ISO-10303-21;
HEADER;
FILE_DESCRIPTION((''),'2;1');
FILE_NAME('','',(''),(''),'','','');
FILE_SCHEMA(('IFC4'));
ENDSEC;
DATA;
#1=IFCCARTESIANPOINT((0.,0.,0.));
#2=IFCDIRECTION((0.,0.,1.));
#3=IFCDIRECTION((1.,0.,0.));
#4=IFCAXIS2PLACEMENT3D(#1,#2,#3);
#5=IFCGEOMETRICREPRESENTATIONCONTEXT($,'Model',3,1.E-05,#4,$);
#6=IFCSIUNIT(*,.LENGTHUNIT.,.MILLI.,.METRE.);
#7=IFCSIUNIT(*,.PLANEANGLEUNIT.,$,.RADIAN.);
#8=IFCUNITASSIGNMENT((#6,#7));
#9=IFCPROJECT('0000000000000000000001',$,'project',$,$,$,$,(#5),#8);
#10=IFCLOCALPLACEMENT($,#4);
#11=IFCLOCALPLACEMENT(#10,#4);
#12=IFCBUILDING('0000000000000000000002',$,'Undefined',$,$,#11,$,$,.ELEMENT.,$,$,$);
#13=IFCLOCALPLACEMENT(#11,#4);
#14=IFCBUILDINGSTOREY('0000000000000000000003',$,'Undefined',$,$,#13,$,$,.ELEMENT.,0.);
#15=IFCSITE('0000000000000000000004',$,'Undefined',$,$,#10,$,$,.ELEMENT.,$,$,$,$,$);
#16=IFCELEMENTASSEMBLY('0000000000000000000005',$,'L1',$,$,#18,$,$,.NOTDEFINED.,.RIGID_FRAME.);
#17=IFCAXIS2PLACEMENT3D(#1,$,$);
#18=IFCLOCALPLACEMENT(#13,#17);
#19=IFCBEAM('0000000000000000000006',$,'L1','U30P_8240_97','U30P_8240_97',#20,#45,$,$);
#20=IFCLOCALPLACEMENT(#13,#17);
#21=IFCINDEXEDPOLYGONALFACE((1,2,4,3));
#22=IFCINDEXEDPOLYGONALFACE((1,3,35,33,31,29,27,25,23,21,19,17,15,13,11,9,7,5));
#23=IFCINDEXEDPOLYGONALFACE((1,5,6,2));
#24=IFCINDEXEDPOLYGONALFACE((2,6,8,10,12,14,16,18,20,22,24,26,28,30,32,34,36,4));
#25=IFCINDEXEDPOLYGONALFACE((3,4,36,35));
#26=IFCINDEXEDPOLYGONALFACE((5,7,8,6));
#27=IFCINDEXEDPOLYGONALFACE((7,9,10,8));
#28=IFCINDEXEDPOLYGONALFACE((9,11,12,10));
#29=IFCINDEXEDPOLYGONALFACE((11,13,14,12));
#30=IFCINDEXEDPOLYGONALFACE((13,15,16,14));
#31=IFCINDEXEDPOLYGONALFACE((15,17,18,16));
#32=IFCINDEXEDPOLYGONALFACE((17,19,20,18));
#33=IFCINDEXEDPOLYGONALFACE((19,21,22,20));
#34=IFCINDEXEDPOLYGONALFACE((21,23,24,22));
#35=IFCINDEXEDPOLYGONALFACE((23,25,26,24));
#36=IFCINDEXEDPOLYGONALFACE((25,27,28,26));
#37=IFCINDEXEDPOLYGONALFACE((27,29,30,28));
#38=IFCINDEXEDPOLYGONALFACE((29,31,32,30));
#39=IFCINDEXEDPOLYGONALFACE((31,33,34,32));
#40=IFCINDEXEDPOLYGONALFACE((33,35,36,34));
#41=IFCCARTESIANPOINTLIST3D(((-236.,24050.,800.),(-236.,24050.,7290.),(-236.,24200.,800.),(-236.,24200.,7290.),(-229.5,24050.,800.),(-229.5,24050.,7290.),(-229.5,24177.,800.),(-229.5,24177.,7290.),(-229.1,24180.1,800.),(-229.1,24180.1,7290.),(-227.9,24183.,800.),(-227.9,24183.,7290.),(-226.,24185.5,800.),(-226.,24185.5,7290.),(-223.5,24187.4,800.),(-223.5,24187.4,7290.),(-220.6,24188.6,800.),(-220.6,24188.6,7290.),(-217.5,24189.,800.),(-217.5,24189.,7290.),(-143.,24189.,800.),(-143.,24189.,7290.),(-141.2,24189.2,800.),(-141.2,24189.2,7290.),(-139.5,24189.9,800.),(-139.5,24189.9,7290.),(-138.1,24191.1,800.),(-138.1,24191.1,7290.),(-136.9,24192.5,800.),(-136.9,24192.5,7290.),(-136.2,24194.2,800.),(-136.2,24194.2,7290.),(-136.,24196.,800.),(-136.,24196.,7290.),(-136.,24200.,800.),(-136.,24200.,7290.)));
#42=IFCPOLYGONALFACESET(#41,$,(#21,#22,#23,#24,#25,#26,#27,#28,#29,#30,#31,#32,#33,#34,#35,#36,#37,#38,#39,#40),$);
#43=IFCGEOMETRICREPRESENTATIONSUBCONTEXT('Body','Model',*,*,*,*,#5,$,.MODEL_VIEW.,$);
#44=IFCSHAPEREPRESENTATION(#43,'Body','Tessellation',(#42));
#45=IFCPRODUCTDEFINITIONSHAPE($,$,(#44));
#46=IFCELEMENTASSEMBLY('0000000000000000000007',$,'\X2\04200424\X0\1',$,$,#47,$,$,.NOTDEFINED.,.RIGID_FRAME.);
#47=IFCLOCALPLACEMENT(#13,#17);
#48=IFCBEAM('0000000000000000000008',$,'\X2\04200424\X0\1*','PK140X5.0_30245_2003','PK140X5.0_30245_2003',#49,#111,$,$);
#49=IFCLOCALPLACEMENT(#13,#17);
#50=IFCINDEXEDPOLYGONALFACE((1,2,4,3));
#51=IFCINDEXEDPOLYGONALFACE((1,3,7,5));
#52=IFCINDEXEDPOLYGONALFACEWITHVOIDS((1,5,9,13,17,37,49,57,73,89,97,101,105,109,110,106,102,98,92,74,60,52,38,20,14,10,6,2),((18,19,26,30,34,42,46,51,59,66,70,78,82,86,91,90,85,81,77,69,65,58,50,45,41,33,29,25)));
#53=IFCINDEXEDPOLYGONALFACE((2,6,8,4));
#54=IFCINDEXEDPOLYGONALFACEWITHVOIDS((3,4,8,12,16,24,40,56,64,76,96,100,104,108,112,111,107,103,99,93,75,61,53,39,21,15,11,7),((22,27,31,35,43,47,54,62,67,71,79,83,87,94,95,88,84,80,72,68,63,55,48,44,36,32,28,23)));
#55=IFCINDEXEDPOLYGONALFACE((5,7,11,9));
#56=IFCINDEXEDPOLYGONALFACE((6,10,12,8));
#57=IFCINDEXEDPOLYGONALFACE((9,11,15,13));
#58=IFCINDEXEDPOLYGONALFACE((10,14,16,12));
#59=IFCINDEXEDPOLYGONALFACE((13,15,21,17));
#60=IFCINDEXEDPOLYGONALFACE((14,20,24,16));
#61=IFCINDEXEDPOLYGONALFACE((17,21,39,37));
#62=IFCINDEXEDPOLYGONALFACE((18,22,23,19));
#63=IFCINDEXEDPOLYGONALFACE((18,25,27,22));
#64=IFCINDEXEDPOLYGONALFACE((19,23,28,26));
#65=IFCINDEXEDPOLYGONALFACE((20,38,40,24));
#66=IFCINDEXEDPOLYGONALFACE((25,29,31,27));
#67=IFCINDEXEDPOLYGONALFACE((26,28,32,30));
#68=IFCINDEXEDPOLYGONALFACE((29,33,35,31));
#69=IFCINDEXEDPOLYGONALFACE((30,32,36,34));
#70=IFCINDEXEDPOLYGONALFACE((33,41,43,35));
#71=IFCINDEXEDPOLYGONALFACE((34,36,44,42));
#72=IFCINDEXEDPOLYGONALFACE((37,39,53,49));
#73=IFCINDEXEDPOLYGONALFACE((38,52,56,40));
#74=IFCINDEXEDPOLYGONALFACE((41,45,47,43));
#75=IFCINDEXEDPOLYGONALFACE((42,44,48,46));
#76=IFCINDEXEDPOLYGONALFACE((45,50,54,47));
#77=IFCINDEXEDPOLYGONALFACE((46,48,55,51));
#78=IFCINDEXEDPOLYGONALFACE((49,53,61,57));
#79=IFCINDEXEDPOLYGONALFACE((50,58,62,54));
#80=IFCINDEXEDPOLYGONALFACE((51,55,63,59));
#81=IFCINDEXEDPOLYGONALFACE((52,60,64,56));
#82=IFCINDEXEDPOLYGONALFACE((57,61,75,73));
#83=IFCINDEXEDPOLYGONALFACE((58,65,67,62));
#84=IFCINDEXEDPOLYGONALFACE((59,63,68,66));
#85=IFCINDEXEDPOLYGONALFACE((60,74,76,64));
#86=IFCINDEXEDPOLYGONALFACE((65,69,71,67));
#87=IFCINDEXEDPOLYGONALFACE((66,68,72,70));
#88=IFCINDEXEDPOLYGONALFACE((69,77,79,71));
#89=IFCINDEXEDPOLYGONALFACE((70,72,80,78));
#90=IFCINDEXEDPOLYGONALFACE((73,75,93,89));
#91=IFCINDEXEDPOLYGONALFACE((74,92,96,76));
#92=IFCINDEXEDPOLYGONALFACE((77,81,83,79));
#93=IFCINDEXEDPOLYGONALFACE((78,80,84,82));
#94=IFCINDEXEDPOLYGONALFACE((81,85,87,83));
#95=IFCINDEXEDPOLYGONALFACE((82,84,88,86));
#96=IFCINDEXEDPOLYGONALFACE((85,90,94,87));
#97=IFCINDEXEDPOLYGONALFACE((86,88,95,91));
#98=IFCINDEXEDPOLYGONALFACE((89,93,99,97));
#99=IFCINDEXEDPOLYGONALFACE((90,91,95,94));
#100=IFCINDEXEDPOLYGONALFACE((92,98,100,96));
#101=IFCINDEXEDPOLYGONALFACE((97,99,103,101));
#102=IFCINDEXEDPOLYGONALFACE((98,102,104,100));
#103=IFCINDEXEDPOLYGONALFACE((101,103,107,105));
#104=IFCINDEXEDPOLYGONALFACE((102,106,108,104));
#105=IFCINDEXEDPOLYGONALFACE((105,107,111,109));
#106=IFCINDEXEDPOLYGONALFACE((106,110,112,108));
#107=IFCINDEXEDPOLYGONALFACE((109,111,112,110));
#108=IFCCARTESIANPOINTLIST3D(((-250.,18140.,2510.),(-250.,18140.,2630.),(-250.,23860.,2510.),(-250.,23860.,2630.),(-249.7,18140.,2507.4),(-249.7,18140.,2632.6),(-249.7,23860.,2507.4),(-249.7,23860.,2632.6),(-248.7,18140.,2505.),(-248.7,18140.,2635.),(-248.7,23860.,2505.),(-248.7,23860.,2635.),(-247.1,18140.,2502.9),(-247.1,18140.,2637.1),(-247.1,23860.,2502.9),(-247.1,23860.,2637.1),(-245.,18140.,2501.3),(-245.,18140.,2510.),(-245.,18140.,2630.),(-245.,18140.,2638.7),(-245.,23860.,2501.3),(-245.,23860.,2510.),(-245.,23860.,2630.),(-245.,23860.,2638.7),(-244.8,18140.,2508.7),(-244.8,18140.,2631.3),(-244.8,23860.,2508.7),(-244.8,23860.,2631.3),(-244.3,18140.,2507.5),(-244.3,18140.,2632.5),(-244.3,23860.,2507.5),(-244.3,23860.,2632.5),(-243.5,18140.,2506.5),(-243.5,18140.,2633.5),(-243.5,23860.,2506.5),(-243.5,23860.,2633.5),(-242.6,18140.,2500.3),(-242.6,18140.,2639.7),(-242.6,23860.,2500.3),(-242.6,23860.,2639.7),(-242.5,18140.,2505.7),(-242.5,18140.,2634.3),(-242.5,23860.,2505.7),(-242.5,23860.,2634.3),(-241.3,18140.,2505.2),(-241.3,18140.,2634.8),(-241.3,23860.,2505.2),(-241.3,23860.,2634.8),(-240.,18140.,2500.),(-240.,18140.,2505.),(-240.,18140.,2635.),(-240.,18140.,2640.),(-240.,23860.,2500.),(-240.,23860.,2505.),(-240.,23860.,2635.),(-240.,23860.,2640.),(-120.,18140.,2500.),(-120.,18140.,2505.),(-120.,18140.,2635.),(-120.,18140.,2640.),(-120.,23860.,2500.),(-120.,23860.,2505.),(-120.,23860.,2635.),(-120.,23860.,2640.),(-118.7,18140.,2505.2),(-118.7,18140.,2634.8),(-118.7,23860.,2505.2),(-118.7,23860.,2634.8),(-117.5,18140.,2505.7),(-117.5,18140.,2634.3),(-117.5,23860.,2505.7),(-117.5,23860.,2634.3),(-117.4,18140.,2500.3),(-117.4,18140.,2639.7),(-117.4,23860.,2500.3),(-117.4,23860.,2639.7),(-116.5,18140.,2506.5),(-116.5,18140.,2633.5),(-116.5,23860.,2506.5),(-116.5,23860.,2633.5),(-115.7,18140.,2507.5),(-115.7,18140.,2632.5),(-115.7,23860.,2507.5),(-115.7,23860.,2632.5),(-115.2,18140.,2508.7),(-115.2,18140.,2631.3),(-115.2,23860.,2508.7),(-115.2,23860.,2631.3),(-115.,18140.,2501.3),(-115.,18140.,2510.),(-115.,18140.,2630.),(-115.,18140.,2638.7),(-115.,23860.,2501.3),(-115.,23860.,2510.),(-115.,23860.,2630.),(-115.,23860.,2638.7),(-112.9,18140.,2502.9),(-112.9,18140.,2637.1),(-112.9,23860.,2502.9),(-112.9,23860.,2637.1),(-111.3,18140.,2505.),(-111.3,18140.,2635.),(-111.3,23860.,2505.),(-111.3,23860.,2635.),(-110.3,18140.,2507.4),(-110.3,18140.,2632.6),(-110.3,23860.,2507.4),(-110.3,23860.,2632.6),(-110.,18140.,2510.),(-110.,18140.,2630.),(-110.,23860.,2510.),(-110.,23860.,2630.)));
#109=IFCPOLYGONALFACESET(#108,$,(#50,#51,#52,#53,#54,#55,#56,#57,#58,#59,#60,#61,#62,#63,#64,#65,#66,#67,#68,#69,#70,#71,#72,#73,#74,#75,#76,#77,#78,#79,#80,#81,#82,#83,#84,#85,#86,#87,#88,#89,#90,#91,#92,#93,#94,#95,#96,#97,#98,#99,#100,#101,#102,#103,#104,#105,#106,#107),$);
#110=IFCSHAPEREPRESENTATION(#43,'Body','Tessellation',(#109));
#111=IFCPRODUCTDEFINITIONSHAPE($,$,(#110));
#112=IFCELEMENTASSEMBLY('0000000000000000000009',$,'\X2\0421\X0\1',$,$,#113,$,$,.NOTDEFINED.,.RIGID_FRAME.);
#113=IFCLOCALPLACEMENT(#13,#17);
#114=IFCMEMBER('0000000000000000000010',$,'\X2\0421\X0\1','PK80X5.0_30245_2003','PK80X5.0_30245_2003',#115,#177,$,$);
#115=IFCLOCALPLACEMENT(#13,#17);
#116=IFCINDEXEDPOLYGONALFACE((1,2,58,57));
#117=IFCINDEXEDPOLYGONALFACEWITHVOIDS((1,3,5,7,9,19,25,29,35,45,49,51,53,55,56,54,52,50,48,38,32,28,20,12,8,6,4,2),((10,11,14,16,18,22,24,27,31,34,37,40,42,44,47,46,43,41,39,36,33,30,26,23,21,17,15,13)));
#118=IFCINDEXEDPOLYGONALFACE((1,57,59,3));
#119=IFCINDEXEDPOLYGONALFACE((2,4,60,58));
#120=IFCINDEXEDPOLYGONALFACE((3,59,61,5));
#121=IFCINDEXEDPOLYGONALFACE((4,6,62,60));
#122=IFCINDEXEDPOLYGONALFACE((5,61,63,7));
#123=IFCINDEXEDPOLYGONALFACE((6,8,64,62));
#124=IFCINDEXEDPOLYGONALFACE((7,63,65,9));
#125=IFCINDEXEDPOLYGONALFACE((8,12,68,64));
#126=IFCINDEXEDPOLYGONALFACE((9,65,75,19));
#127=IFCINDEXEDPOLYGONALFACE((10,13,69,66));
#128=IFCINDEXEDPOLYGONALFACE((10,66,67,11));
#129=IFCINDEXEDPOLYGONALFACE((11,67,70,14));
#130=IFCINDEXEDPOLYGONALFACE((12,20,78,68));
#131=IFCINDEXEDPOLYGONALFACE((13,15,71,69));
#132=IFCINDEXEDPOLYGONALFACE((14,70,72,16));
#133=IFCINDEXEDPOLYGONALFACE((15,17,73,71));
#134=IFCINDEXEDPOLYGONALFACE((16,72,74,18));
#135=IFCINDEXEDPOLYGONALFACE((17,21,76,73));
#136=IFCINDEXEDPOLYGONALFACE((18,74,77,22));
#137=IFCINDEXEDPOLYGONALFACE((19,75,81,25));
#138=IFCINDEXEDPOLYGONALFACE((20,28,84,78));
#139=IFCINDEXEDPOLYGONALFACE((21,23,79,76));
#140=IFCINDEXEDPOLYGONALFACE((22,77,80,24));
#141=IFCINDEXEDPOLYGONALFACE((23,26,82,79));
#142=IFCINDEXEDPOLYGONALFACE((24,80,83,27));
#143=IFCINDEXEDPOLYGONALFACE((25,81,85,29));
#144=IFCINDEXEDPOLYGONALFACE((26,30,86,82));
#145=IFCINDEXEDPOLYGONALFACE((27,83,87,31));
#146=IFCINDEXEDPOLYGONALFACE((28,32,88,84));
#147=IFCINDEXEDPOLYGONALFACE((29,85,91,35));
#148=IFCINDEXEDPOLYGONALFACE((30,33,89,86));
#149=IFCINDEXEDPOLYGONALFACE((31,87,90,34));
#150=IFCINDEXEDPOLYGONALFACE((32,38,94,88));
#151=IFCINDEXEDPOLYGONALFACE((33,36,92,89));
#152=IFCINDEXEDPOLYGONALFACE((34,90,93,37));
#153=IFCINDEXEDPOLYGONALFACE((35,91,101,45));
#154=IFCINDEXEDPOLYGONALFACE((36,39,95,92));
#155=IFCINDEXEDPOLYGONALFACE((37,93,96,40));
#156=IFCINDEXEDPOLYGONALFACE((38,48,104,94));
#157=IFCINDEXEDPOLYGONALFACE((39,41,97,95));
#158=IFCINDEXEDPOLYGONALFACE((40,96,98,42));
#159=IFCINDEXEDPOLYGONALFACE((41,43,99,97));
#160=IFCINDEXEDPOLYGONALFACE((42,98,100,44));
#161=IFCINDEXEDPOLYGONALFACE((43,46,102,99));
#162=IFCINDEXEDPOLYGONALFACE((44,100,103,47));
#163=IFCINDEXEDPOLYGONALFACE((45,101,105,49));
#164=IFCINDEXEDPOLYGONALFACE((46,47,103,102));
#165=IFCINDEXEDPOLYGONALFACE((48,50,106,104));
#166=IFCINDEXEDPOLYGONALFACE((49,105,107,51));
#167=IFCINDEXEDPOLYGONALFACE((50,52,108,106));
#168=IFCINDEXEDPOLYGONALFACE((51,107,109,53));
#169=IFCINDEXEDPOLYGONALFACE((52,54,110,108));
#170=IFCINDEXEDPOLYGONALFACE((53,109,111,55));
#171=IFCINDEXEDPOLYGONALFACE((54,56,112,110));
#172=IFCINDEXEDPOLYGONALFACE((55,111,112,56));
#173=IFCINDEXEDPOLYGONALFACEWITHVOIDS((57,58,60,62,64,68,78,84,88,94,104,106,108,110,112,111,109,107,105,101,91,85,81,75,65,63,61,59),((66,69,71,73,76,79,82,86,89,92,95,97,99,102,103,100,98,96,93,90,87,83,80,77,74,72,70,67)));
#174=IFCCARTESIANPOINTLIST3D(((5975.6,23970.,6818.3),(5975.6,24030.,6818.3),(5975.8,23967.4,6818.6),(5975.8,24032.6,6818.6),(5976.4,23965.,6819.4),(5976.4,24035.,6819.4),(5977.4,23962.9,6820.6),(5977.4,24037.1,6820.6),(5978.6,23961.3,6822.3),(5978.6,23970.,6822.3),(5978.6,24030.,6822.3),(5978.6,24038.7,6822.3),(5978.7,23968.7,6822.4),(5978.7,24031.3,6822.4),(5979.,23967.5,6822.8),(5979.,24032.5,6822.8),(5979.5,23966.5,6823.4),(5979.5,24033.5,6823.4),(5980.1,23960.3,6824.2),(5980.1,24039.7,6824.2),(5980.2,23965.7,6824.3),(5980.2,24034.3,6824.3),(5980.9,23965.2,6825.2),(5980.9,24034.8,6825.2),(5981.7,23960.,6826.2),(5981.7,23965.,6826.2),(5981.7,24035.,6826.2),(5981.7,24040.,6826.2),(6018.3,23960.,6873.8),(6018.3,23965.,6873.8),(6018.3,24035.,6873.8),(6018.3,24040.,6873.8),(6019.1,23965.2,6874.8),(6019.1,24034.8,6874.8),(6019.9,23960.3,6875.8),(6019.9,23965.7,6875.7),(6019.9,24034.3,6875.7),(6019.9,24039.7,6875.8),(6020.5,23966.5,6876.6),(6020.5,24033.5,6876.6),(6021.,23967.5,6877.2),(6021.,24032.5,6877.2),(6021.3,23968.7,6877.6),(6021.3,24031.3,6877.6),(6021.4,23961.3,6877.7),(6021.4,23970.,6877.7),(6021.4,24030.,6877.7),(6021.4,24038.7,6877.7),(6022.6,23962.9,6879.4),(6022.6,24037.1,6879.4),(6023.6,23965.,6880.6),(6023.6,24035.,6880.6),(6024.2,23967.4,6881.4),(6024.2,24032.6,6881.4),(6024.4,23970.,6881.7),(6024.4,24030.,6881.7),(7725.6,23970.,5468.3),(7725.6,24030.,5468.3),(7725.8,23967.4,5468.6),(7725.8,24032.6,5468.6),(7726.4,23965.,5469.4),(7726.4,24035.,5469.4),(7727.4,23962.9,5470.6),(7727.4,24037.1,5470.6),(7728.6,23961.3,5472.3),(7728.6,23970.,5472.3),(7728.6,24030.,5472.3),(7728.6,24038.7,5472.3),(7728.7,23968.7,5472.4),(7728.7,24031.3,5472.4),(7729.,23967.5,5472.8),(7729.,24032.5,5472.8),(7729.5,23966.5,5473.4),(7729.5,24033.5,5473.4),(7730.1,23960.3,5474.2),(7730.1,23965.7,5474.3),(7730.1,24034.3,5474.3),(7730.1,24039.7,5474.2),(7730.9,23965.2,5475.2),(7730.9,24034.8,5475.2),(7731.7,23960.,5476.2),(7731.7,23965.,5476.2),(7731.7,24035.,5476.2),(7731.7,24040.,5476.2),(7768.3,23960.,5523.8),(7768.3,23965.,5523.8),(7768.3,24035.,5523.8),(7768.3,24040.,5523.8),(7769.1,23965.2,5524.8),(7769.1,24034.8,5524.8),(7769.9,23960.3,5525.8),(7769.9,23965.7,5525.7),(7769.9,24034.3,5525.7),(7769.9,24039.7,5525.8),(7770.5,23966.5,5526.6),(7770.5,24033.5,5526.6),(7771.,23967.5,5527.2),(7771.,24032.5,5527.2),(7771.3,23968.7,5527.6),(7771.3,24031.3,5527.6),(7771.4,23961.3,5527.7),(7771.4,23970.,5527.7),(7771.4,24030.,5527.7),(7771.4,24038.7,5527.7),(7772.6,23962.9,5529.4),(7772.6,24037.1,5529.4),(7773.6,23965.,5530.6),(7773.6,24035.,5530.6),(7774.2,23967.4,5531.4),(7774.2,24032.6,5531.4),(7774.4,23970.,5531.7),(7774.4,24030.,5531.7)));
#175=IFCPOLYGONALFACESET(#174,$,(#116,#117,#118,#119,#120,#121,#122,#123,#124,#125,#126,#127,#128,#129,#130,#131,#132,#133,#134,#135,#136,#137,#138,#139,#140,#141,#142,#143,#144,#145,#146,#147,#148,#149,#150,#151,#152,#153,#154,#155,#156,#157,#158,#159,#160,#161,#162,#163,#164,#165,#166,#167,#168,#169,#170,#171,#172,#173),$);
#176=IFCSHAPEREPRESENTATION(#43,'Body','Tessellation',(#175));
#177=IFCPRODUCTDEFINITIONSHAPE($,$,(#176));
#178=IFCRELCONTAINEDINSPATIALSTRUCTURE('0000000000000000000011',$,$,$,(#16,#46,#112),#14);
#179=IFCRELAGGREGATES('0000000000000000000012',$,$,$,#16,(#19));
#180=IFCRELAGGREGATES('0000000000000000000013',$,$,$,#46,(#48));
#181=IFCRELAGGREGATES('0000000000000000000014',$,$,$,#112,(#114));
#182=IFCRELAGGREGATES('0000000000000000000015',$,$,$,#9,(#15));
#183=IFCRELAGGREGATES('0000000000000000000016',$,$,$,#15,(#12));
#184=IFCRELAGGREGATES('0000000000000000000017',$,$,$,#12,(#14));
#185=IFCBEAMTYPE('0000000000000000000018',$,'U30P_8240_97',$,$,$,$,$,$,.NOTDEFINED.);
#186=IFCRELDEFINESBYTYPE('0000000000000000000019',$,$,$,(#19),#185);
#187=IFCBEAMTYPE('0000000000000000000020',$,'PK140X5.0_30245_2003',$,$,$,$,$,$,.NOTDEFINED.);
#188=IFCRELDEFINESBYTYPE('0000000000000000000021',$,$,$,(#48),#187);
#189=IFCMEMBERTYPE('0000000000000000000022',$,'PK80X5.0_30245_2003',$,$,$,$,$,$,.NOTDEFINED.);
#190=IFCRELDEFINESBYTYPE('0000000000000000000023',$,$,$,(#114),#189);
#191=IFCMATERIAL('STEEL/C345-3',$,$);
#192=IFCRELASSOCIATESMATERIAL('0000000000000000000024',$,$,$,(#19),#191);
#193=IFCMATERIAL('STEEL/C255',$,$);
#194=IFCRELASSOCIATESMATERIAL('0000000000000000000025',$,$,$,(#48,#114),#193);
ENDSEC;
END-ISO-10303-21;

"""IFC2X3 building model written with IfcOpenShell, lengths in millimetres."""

from ifc_helpers import new_model, si_unit, frame, origin_with_axes, origin_2d_with_axis, place, context, subcontext, project, spatial, hollow_rectangle, u_section, extrude, clip, halfspace, material, type_object, element, aggregate, save


model = new_model("IFC2X3")

# Units and contexts
model_context = context("Model", 3, precision=1e-05, world=origin_with_axes())
body_context = subcontext(model_context, "Body", "Model", "MODEL_VIEW")
ifc_project = project(units=[si_unit("LENGTHUNIT", "METRE", prefix="MILLI"), si_unit("PLANEANGLEUNIT", "RADIAN")], contexts=[model_context])

# Site, building, storey
site_placement = place(None, origin_with_axes())
site = spatial("IfcSite", under=ifc_project, at=site_placement, Name="Undefined", CompositionType="ELEMENT")
building_placement = place(site_placement, origin_with_axes())
building = spatial("IfcBuilding", under=site, at=building_placement, Name="Undefined", CompositionType="ELEMENT")
storey_placement = place(building_placement, origin_with_axes())
storey = spatial("IfcBuildingStorey", under=building, at=storey_placement, Name="Undefined", CompositionType="ELEMENT", Elevation=0.0)

# Shared definitions
ifc_material_1 = material(Name="STEEL/C255")

# Element assemblies, beams
ifc_material_2 = material(Name="STEEL/C345-3")
assembly_1_placement = place(storey_placement, origin_with_axes())
assembly_1 = element("IfcElementAssembly", 1, at=assembly_1_placement, inside=storey, Name="L1", AssemblyPlace="NOTDEFINED", PredefinedType="RIGID_FRAME")
beam_type_1 = type_object("IfcBeamType", Name="U30P_8240_97", PredefinedType="NOTDEFINED")
beam_1_placement = place(assembly_1_placement, frame((-186.0, 24050.0, 7290.0), z_axis=(0.0, 1.0, 0.0), x_axis=(0.0, 0.0, -1.0)))
beam_1 = element("IfcBeam", 2, at=beam_1_placement, type_object=beam_type_1, material=ifc_material_2, Name="L1", Description="U30P_8240_97", ObjectType="U30P_8240_97", context=body_context, shape_type="Clipping", body=[
    clip(extrude(u_section(Depth=300.0, FlangeWidth=100.0, WebThickness=6.5, FlangeThickness=11.0, FilletRadius=12.0, EdgeRadius=7.0, at=origin_2d_with_axis()), frame((6490.0, 0.0, 0.0), z_axis=(-1.0, 0.0, 0.0), x_axis=(0.0, -1.0, 0.0)), (0.0, 0.0, 1.0), 6490.0), halfspace(frame((6490.0, 50.0, 0.0), z_axis=(0.0, 0.0, -1.0), x_axis=(-1.0, 0.0, 0.0)), False)),
])
aggregate(assembly_1, [beam_1])
assembly_2_placement = place(storey_placement, origin_with_axes())
assembly_2 = element("IfcElementAssembly", 3, at=assembly_2_placement, inside=storey, Name="РФ1", AssemblyPlace="NOTDEFINED", PredefinedType="RIGID_FRAME")
beam_type_2 = type_object("IfcBeamType", Name="PK140X5.0_30245_2003", PredefinedType="NOTDEFINED")
beam_2_placement = place(assembly_2_placement, frame((-180.0, 18140.0, 2570.0), z_axis=(1.0, 0.0, 0.0), x_axis=(0.0, 1.0, 0.0)))
beam_2 = element("IfcBeam", 4, at=beam_2_placement, type_object=beam_type_2, material=ifc_material_1, Name="РФ1*", Description="PK140X5.0_30245_2003", ObjectType="PK140X5.0_30245_2003", context=body_context, shape_type="SweptSolid", body=[
    extrude(hollow_rectangle(XDim=140.0, YDim=140.0, WallThickness=5.0, InnerFilletRadius=5.0, OuterFilletRadius=10.0, at=origin_2d_with_axis()), frame((5720.0, 0.0, 0.0), z_axis=(-1.0, 0.0, 0.0), x_axis=(0.0, -1.0, 0.0)), (0.0, 0.0, 1.0), 5720.0),
])
aggregate(assembly_2, [beam_2])

# Element assembly, member
assembly_3_placement = place(storey_placement, origin_with_axes())
assembly_3 = element("IfcElementAssembly", 5, at=assembly_3_placement, inside=storey, Name="С1", AssemblyPlace="NOTDEFINED", PredefinedType="RIGID_FRAME")
member_type = type_object("IfcMemberType", Name="PK80X5.0_30245_2003", PredefinedType="NOTDEFINED")
member_1_placement = place(assembly_3_placement, frame((6000.0, 24000.0, 6850.0), z_axis=(0.0, -1.0, 0.0), x_axis=(0.791782, 0.0, -0.610803)))
member_1 = element("IfcMember", 6, at=member_1_placement, type_object=member_type, material=ifc_material_1, Name="С1", Description="PK80X5.0_30245_2003", ObjectType="PK80X5.0_30245_2003", context=body_context, shape_type="SweptSolid", body=[
    extrude(hollow_rectangle(XDim=80.0, YDim=80.0, WallThickness=5.0, InnerFilletRadius=5.0, OuterFilletRadius=10.0, at=origin_2d_with_axis()), frame((2210.2, 0.0, 0.0), z_axis=(-1.0, 0.0, 0.0), x_axis=(0.0, -1.0, 0.0)), (0.0, 0.0, 1.0), 2210.2),
])
aggregate(assembly_3, [member_1])

save(model, "model.ifc")
